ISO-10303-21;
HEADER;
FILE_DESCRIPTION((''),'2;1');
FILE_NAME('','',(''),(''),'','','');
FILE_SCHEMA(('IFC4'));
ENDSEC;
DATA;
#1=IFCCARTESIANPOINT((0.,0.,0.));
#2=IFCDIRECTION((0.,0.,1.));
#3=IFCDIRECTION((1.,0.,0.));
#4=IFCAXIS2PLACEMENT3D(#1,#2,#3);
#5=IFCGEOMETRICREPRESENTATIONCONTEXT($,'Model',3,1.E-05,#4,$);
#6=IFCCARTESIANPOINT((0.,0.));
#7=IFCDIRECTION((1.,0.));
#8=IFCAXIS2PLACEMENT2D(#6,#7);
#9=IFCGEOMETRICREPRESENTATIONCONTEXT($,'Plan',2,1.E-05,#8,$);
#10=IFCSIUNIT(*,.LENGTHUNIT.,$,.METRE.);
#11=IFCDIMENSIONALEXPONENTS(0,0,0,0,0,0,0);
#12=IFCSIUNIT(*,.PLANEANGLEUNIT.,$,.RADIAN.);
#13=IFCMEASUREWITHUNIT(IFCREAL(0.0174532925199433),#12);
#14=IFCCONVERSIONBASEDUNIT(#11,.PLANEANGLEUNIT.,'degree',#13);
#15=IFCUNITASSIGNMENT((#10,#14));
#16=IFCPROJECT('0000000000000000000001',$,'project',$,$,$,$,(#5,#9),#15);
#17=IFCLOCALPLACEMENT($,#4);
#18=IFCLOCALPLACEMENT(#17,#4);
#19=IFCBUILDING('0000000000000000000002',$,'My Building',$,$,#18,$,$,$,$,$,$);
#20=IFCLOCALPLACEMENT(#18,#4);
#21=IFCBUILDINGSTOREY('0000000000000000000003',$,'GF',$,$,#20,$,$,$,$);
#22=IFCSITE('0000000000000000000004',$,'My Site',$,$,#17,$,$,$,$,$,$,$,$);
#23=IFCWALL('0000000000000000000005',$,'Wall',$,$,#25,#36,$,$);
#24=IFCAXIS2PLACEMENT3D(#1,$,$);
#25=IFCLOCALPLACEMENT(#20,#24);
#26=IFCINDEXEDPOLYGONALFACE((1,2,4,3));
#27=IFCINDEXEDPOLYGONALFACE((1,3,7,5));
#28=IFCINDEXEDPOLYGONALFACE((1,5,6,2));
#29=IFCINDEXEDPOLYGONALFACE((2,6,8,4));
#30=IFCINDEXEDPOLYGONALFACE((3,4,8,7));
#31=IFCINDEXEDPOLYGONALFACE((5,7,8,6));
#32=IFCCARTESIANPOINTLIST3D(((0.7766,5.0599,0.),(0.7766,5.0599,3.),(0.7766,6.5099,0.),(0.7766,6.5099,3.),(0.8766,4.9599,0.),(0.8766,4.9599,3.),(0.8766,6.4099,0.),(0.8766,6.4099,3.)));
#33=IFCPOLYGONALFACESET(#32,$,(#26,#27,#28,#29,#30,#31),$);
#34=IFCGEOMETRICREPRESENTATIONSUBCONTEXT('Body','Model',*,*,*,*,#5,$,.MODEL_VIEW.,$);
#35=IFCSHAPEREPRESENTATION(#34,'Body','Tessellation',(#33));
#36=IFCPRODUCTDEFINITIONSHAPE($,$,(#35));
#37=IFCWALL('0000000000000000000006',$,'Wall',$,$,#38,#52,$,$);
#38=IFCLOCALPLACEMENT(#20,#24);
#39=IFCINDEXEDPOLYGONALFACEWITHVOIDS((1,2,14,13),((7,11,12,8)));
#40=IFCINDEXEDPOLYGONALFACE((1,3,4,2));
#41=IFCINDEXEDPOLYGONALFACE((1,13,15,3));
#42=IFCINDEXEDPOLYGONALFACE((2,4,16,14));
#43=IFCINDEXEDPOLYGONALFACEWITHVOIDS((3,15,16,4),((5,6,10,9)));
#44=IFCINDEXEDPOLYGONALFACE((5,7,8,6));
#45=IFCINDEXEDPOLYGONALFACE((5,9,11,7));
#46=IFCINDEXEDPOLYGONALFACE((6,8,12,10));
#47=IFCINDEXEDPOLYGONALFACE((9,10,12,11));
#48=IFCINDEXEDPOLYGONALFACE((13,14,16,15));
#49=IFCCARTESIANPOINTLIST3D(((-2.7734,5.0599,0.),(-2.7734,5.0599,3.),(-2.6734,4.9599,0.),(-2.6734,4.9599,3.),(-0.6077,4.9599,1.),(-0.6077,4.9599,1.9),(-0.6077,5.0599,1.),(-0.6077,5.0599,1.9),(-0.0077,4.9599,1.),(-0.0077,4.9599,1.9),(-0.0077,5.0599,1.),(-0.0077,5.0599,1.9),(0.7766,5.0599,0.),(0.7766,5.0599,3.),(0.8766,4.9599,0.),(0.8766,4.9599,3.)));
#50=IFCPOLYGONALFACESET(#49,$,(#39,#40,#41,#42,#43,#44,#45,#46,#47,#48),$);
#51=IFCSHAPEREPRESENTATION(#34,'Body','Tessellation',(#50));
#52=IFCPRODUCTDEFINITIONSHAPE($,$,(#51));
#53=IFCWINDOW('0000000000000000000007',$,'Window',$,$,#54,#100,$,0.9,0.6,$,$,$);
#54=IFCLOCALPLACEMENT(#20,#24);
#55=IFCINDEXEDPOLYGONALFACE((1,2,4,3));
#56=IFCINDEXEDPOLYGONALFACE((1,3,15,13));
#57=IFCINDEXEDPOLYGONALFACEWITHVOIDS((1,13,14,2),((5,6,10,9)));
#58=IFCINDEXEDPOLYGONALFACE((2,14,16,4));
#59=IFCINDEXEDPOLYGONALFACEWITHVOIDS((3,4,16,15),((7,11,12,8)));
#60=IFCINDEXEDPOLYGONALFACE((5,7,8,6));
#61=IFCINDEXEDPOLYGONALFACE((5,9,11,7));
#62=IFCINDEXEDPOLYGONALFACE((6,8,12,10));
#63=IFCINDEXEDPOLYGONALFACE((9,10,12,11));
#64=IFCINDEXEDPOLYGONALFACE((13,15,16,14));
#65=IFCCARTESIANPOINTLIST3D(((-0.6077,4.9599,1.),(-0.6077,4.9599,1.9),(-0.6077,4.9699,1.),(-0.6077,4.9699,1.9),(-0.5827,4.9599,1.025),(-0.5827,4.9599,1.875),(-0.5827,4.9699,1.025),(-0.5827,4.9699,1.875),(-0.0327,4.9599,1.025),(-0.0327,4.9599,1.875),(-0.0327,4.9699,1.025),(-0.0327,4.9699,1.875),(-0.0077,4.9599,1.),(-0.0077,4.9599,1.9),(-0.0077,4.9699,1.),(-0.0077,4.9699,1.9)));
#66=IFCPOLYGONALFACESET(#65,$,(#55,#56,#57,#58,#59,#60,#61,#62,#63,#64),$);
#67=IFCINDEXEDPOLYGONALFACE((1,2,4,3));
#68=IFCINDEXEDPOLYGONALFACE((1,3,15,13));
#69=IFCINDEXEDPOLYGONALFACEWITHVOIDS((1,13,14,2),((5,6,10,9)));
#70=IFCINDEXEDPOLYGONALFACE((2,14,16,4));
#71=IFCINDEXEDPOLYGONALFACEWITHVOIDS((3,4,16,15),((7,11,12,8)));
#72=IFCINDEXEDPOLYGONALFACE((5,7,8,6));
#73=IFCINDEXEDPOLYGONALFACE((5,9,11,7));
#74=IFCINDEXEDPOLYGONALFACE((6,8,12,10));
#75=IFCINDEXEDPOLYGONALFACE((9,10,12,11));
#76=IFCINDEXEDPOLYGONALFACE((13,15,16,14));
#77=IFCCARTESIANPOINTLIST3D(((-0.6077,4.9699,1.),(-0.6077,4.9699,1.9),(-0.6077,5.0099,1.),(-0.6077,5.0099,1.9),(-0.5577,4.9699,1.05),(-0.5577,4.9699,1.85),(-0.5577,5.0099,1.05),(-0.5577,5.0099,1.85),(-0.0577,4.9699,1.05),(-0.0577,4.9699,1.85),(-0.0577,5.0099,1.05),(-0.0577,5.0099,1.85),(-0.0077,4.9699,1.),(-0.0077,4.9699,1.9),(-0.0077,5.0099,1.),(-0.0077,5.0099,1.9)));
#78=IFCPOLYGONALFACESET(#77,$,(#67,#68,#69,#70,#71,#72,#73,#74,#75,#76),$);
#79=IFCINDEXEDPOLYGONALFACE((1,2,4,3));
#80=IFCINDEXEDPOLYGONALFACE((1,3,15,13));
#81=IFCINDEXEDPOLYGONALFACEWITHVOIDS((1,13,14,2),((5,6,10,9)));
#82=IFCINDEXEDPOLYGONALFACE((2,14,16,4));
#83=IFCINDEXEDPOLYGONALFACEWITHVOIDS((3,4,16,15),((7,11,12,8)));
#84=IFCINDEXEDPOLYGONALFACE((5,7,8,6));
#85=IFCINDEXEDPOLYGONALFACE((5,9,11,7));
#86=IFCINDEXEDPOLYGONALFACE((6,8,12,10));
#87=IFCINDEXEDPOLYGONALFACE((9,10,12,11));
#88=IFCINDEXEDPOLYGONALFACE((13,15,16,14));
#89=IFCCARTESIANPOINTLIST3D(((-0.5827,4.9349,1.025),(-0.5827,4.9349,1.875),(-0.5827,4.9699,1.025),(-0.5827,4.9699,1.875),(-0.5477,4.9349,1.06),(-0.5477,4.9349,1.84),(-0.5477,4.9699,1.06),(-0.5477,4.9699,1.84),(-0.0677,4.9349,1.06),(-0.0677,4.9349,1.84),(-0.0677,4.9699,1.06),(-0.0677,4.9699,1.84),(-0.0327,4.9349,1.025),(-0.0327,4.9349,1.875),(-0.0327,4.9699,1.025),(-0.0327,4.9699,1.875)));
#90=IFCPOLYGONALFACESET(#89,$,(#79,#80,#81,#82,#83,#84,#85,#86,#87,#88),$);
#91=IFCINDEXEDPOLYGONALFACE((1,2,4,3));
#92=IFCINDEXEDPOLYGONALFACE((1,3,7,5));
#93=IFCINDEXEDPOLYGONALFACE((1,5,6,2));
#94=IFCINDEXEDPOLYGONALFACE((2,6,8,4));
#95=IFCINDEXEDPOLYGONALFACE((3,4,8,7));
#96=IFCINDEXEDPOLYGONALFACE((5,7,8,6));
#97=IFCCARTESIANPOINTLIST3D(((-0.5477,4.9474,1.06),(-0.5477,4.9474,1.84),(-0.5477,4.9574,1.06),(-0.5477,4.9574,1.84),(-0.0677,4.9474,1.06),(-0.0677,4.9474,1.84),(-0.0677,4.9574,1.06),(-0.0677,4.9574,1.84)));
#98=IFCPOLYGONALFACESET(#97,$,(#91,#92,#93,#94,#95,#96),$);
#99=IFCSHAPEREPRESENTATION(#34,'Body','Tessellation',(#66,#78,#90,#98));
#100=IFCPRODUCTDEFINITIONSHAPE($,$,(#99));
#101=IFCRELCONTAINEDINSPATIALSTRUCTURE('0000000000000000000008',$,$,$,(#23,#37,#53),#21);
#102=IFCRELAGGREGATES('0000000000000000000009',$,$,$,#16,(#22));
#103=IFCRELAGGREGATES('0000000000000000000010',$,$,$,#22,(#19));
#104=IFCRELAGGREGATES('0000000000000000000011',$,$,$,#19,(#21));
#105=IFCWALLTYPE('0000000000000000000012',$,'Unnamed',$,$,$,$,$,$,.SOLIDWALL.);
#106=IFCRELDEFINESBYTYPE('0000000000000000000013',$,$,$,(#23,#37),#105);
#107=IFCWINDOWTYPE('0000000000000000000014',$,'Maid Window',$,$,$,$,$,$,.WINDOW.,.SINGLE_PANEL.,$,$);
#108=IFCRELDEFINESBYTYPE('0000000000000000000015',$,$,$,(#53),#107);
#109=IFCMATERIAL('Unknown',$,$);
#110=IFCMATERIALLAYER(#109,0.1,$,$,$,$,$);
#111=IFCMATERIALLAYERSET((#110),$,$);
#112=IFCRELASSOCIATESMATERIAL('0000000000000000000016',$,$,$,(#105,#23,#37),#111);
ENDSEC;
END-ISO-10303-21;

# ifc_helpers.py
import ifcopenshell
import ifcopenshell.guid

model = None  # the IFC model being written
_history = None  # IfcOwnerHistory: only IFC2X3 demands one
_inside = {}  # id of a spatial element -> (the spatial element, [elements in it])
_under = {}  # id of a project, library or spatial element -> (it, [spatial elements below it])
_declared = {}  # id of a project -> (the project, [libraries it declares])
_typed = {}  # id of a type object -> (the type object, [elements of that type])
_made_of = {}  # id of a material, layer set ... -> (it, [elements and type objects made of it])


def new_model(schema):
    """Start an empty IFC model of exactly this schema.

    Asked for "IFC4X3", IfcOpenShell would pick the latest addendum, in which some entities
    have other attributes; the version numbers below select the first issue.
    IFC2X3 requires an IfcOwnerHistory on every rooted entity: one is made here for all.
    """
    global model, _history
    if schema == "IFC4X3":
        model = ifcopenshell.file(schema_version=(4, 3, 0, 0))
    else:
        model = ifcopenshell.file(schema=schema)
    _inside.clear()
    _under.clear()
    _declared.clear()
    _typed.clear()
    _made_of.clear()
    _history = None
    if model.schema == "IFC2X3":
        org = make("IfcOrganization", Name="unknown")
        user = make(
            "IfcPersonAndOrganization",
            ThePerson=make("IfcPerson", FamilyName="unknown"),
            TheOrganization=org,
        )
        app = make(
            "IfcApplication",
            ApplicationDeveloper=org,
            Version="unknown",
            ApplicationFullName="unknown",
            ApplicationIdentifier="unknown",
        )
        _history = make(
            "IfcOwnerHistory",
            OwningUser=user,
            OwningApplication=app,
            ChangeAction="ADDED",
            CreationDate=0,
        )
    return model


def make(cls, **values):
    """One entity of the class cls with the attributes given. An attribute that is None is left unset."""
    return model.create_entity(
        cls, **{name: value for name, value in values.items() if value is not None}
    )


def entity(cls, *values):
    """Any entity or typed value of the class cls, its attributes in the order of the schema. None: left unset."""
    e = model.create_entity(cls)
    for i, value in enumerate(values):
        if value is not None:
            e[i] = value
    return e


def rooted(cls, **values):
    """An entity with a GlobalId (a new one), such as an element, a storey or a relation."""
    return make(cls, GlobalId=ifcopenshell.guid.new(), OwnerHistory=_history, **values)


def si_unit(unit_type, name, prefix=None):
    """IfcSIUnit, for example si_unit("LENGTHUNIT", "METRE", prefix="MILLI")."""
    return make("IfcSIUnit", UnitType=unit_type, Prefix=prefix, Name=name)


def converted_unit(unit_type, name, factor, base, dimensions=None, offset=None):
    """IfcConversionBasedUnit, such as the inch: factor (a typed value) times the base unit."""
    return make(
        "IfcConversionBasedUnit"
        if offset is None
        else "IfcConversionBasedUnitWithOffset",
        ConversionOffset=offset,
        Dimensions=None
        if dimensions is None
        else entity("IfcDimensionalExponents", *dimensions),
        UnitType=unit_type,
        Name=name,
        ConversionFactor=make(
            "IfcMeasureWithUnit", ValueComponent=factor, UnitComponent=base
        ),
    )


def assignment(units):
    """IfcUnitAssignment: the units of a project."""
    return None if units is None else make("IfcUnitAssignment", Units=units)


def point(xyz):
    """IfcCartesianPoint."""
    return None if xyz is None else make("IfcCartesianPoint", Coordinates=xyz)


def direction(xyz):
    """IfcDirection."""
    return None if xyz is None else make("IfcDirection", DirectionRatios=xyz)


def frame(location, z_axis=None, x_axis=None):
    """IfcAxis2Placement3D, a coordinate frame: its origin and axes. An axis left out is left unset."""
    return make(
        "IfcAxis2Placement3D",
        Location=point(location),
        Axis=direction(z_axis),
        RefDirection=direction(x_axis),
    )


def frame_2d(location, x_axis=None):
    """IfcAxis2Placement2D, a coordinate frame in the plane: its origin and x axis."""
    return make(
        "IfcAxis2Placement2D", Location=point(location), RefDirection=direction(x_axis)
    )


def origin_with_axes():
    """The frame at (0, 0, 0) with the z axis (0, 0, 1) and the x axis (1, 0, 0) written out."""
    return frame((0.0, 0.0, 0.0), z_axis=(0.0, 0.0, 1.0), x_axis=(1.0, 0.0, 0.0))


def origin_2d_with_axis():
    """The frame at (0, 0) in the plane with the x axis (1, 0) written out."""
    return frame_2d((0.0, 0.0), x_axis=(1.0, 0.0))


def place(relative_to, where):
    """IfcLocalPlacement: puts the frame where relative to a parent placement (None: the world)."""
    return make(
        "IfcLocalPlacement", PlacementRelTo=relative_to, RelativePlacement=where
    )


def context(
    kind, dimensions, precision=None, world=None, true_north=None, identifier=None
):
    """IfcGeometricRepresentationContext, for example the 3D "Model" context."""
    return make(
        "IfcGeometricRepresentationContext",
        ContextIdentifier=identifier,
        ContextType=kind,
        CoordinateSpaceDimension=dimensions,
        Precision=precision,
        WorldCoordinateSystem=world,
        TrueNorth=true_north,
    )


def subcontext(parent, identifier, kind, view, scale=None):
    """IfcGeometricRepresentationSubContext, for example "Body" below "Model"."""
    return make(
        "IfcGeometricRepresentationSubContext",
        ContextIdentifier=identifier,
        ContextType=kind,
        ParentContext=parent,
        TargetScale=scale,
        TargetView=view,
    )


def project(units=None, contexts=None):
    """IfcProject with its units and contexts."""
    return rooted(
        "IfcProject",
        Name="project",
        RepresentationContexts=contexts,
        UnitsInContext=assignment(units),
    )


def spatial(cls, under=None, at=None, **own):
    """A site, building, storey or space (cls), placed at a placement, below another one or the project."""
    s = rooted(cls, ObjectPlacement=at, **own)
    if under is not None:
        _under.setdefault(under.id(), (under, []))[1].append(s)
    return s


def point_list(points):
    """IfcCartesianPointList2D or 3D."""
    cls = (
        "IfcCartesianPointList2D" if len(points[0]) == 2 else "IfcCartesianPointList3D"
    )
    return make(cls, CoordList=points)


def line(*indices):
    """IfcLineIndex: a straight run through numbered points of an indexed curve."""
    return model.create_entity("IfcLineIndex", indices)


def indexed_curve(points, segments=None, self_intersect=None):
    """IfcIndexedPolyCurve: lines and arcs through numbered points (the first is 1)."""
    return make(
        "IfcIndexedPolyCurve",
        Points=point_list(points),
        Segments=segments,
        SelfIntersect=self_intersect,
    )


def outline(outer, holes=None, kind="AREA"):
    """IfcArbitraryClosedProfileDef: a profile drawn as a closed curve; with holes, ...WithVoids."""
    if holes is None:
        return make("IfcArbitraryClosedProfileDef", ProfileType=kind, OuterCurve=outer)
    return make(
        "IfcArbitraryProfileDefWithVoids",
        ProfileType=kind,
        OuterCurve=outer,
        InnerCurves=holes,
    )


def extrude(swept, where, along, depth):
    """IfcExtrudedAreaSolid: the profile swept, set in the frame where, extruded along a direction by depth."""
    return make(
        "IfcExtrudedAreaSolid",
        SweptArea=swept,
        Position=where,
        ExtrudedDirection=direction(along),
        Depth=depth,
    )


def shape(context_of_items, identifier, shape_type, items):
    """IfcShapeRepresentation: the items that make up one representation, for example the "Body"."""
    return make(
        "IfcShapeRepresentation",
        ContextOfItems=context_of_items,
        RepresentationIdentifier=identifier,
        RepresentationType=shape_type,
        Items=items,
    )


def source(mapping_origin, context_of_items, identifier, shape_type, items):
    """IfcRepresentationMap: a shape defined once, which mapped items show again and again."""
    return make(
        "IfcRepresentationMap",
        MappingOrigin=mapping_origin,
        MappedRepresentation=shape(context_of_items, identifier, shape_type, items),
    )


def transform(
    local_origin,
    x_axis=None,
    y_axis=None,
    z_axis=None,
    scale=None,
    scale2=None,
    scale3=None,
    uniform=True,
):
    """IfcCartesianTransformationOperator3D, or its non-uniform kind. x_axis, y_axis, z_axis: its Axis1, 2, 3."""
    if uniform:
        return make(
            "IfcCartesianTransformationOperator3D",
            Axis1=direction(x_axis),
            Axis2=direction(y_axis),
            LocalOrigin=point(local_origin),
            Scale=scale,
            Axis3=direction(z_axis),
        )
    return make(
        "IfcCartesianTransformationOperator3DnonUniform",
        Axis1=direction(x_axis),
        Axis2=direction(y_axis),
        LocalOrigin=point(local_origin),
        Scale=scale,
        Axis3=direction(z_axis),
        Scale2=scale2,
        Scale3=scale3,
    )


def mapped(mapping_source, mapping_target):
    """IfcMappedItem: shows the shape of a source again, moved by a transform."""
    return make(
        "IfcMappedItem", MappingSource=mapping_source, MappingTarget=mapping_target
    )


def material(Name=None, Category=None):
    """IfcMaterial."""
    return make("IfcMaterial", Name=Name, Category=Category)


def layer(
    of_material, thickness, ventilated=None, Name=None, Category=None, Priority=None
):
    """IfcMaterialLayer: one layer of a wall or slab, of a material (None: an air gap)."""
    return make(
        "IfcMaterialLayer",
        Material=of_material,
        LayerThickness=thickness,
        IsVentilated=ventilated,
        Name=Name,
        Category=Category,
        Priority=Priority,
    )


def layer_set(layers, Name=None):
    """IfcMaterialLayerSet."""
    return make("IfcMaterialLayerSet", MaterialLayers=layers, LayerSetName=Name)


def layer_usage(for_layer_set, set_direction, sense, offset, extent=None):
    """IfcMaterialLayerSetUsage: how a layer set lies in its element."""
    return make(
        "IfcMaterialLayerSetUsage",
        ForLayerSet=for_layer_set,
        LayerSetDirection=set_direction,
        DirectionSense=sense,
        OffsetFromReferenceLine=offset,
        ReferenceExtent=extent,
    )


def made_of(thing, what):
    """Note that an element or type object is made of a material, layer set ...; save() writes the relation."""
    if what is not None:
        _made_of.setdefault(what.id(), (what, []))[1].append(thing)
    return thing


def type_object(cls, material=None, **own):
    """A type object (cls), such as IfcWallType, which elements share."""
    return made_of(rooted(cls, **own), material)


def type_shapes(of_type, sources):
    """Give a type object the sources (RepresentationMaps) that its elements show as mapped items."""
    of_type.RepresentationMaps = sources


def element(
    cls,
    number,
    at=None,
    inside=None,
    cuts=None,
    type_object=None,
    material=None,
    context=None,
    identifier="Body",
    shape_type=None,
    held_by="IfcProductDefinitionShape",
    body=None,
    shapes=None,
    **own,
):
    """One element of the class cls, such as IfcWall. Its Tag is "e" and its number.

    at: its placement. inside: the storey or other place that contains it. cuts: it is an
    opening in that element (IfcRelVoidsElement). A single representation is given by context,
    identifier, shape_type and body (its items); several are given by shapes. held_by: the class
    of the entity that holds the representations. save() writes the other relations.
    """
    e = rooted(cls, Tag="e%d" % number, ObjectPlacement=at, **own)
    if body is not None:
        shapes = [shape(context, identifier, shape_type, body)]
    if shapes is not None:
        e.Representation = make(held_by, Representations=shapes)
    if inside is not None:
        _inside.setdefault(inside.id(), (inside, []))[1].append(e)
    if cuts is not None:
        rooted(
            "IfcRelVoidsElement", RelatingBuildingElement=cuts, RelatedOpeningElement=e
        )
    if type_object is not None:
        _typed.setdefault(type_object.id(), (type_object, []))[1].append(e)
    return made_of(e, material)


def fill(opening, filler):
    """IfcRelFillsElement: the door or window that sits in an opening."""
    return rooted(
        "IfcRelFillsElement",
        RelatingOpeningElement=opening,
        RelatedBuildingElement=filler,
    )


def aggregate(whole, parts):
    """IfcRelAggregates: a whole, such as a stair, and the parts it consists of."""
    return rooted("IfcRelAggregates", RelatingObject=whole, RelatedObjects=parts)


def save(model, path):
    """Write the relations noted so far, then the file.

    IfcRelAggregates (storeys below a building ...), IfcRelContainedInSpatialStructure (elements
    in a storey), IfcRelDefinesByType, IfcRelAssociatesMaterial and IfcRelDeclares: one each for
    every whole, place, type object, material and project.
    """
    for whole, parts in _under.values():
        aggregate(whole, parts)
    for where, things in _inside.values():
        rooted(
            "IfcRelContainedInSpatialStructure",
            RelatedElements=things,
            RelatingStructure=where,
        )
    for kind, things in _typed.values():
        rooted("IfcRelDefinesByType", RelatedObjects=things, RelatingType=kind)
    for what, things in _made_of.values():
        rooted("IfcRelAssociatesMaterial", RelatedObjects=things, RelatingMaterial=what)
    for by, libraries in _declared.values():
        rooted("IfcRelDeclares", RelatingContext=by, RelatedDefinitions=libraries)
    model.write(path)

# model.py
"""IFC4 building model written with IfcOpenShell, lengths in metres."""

from ifc_helpers import new_model, entity, si_unit, converted_unit, frame, origin_with_axes, origin_2d_with_axis, place, context, subcontext, project, spatial, line, indexed_curve, outline, extrude, shape, source, transform, mapped, material, layer, layer_set, layer_usage, type_object, type_shapes, element, fill, save


model = new_model("IFC4")

# Units and contexts
model_context = context("Model", 3, precision=1e-05, world=origin_with_axes())
plan_context = context("Plan", 2, precision=1e-05, world=origin_2d_with_axis())
body_context_1 = subcontext(model_context, "Body", "Model", "MODEL_VIEW")
body_context_2 = subcontext(plan_context, "Body", "Plan", "PLAN_VIEW")
ifc_project = project(units=[si_unit("LENGTHUNIT", "METRE"), converted_unit("PLANEANGLEUNIT", "degree", entity("IfcReal", 0.0174532925199433), si_unit("PLANEANGLEUNIT", "RADIAN"), dimensions=[0, 0, 0, 0, 0, 0, 0])], contexts=[model_context, plan_context])

# Site, building, storey
site_placement = place(None, origin_with_axes())
site = spatial("IfcSite", under=ifc_project, at=site_placement, Name="My Site")
building_placement = place(site_placement, origin_with_axes())
building = spatial("IfcBuilding", under=site, at=building_placement, Name="My Building")
storey_placement = place(building_placement, origin_with_axes())
storey = spatial("IfcBuildingStorey", under=building, at=storey_placement, Name="GF")

# Shared definitions
ifc_material = material(Name="Unknown")

# Wall
ifc_layer_1 = layer(ifc_material, 0.1)
ifc_layer_set_1 = layer_set([ifc_layer_1])
wall_type = type_object("IfcWallType", Name="Unnamed", PredefinedType="SOLIDWALL", material=ifc_layer_set_1)
ifc_layer_usage_1 = layer_usage(ifc_layer_set_1, "AXIS2", "POSITIVE", 0.0)
wall_1_placement = place(storey_placement, frame((0.7766, 6.5099, 0.0), z_axis=(0.0, 0.0, 1.0), x_axis=(0.0, -1.0, 0.0)))
element("IfcWall", 1, at=wall_1_placement, inside=storey, type_object=wall_type, material=ifc_layer_usage_1, Name="Wall", context=body_context_1, shape_type="SweptSolid", body=[
    extrude(outline(indexed_curve([(0.0, 0.0), (0.1, 0.1), (1.55, 0.1), (1.45, 0.0)], segments=[line(1, 2, 3, 4, 1)])), origin_with_axes(), (0.0, 0.0, 1.0), 3.0),
])

# Wall, opening, window
ifc_layer_usage_2 = layer_usage(ifc_layer_set_1, "AXIS2", "POSITIVE", 0.0)
wall_2_placement = place(storey_placement, frame((0.7766, 5.0599, 0.0), z_axis=(0.0, 0.0, 1.0), x_axis=(-1.0, 0.0, 0.0)))
wall_2 = element("IfcWall", 2, at=wall_2_placement, inside=storey, type_object=wall_type, material=ifc_layer_usage_2, Name="Wall", context=body_context_1, shape_type="SweptSolid", body=[
    extrude(outline(indexed_curve([(0.0, 0.0), (-0.1, 0.1), (3.45, 0.1), (3.55, 0.0)], segments=[line(1, 2, 3, 4, 1)])), origin_with_axes(), (0.0, 0.0, 1.0), 3.0),
])
shared_shape_1 = source(origin_with_axes(), body_context_1, "Body", "SweptSolid", [
    extrude(outline(indexed_curve([(0.0, 0.0), (0.6, 0.0), (0.6, 0.9), (0.0, 0.9)], segments=[line(1, 2, 3, 4, 1)])), frame((0.0, -0.6, 0.0), z_axis=(0.0, -1.0, 0.0), x_axis=(1.0, 0.0, 0.0)), (0.0, 0.0, -1.0), 1.2),
])
opening_1_placement = place(wall_2_placement, frame((0.7843, 0.0, 1.0), z_axis=(0.0, 0.0, 1.0), x_axis=(1.0, 0.0, 0.0)))
opening_1 = element("IfcOpeningElement", 3, at=opening_1_placement, cuts=wall_2, PredefinedType="OPENING", context=body_context_1, shape_type="MappedRepresentation", body=[
    mapped(shared_shape_1, transform((0.0, 0.0, 0.0), x_axis=(1.0, 0.0, 0.0), y_axis=(0.0, 1.0, 0.0), z_axis=(0.0, 0.0, 1.0), scale=1.0)),
])
window_type_1 = type_object("IfcWindowType", Name="Maid Window", PartitioningType="SINGLE_PANEL", PredefinedType="WINDOW")
shared_shape_2 = source(origin_with_axes(), body_context_1, "Body", "SweptSolid", [
    extrude(outline(indexed_curve([(0.0, 0.0), (0.6, 0.0), (0.6, 0.9), (0.0, 0.9)], segments=[line(1, 2, 3, 4, 1)]), holes=[indexed_curve([(0.025, 0.025), (0.575, 0.025), (0.575, 0.875), (0.025, 0.875)], segments=[line(1, 2, 3, 4, 1)])]), frame((0.0, 0.09, 0.0), z_axis=(0.0, -1.0, 0.0), x_axis=(1.0, 0.0, 0.0)), (0.0, 0.0, -1.0), 0.01),
    extrude(outline(indexed_curve([(0.0, 0.0), (0.6, 0.0), (0.6, 0.9), (0.0, 0.9)], segments=[line(1, 2, 3, 4, 1)]), holes=[indexed_curve([(0.05, 0.05), (0.55, 0.05), (0.55, 0.85), (0.05, 0.85)], segments=[line(1, 2, 3, 4, 1)])]), frame((0.0, 0.05, 0.0), z_axis=(0.0, -1.0, 0.0), x_axis=(1.0, 0.0, 0.0)), (0.0, 0.0, -1.0), 0.04),
    extrude(outline(indexed_curve([(0.0, 0.0), (0.55, 0.0), (0.55, 0.85), (0.0, 0.85)], segments=[line(1, 2, 3, 4, 1)]), holes=[indexed_curve([(0.035, 0.035), (0.515, 0.035), (0.515, 0.815), (0.035, 0.815)], segments=[line(1, 2, 3, 4, 1)])]), frame((0.025, 0.09, 0.025), z_axis=(0.0, -1.0, 0.0), x_axis=(1.0, 0.0, 0.0)), (0.0, 0.0, -1.0), 0.035),
    extrude(outline(indexed_curve([(0.035, 0.035), (0.515, 0.035), (0.515, 0.815), (0.035, 0.815)], segments=[line(1, 2, 3, 4, 1)])), frame((0.025, 0.1025, 0.025), z_axis=(0.0, -1.0, 0.0), x_axis=(1.0, 0.0, 0.0)), (0.0, 0.0, -1.0), 0.01),
])
shared_shape_3 = source(origin_with_axes(), body_context_2, "Body", "Curve2D", [
    entity("IfcIndexedPolyCurve", entity("IfcCartesianPointList2D", [[0.05, 0.05], [0.55, 0.05]])),
    entity("IfcIndexedPolyCurve", entity("IfcCartesianPointList2D", [[0.0, 0.1], [0.025, 0.1], [0.025, 0.09], [0.05, 0.09], [0.05, 0.05], [0.0, 0.05]]), [entity("IfcLineIndex", [1, 2, 3, 4, 5, 6, 1])]),
    entity("IfcIndexedPolyCurve", entity("IfcCartesianPointList2D", [[0.6, 0.1], [0.575, 0.1], [0.575, 0.09], [0.55, 0.09], [0.55, 0.05], [0.6, 0.05]]), [entity("IfcLineIndex", [1, 2, 3, 4, 5, 6, 1])]),
    entity("IfcIndexedPolyCurve", entity("IfcCartesianPointList2D", [[0.025, 0.09], [0.06, 0.09], [0.06, 0.125], [0.025, 0.125]]), [entity("IfcLineIndex", [1, 2, 3, 4, 1])]),
    entity("IfcIndexedPolyCurve", entity("IfcCartesianPointList2D", [[0.575, 0.09], [0.54, 0.09], [0.54, 0.125], [0.575, 0.125]]), [entity("IfcLineIndex", [1, 2, 3, 4, 1])]),
    entity("IfcIndexedPolyCurve", entity("IfcCartesianPointList2D", [[0.06, 0.09], [0.54, 0.09]])),
    entity("IfcIndexedPolyCurve", entity("IfcCartesianPointList2D", [[0.06, 0.125], [0.54, 0.125]])),
    entity("IfcIndexedPolyCurve", entity("IfcCartesianPointList2D", [[0.06, 0.1075], [0.54, 0.1075]])),
])
type_shapes(window_type_1, [shared_shape_2, shared_shape_3])
window_1_placement = place(opening_1_placement, frame((0.0, 0.0, 0.0), z_axis=(0.0, 0.0, 1.0), x_axis=(1.0, 0.0, 0.0)))
window_1 = element("IfcWindow", 4, at=window_1_placement, inside=storey, type_object=window_type_1, Name="Window", OverallHeight=0.9, OverallWidth=0.6, shapes=[
    shape(body_context_1, "Body", "MappedRepresentation", [mapped(shared_shape_2, transform((0.0, 0.0, 0.0), x_axis=(1.0, 0.0, 0.0), y_axis=(0.0, 1.0, 0.0), z_axis=(0.0, 0.0, 1.0), scale=1.0))]),
    shape(body_context_2, "Body", "MappedRepresentation", [mapped(shared_shape_3, transform((0.0, 0.0, 0.0), x_axis=(1.0, 0.0, 0.0), y_axis=(0.0, 1.0, 0.0), z_axis=(0.0, 0.0, 1.0), scale=1.0))]),
])
fill(opening_1, window_1)

save(model, "model.ifc")
